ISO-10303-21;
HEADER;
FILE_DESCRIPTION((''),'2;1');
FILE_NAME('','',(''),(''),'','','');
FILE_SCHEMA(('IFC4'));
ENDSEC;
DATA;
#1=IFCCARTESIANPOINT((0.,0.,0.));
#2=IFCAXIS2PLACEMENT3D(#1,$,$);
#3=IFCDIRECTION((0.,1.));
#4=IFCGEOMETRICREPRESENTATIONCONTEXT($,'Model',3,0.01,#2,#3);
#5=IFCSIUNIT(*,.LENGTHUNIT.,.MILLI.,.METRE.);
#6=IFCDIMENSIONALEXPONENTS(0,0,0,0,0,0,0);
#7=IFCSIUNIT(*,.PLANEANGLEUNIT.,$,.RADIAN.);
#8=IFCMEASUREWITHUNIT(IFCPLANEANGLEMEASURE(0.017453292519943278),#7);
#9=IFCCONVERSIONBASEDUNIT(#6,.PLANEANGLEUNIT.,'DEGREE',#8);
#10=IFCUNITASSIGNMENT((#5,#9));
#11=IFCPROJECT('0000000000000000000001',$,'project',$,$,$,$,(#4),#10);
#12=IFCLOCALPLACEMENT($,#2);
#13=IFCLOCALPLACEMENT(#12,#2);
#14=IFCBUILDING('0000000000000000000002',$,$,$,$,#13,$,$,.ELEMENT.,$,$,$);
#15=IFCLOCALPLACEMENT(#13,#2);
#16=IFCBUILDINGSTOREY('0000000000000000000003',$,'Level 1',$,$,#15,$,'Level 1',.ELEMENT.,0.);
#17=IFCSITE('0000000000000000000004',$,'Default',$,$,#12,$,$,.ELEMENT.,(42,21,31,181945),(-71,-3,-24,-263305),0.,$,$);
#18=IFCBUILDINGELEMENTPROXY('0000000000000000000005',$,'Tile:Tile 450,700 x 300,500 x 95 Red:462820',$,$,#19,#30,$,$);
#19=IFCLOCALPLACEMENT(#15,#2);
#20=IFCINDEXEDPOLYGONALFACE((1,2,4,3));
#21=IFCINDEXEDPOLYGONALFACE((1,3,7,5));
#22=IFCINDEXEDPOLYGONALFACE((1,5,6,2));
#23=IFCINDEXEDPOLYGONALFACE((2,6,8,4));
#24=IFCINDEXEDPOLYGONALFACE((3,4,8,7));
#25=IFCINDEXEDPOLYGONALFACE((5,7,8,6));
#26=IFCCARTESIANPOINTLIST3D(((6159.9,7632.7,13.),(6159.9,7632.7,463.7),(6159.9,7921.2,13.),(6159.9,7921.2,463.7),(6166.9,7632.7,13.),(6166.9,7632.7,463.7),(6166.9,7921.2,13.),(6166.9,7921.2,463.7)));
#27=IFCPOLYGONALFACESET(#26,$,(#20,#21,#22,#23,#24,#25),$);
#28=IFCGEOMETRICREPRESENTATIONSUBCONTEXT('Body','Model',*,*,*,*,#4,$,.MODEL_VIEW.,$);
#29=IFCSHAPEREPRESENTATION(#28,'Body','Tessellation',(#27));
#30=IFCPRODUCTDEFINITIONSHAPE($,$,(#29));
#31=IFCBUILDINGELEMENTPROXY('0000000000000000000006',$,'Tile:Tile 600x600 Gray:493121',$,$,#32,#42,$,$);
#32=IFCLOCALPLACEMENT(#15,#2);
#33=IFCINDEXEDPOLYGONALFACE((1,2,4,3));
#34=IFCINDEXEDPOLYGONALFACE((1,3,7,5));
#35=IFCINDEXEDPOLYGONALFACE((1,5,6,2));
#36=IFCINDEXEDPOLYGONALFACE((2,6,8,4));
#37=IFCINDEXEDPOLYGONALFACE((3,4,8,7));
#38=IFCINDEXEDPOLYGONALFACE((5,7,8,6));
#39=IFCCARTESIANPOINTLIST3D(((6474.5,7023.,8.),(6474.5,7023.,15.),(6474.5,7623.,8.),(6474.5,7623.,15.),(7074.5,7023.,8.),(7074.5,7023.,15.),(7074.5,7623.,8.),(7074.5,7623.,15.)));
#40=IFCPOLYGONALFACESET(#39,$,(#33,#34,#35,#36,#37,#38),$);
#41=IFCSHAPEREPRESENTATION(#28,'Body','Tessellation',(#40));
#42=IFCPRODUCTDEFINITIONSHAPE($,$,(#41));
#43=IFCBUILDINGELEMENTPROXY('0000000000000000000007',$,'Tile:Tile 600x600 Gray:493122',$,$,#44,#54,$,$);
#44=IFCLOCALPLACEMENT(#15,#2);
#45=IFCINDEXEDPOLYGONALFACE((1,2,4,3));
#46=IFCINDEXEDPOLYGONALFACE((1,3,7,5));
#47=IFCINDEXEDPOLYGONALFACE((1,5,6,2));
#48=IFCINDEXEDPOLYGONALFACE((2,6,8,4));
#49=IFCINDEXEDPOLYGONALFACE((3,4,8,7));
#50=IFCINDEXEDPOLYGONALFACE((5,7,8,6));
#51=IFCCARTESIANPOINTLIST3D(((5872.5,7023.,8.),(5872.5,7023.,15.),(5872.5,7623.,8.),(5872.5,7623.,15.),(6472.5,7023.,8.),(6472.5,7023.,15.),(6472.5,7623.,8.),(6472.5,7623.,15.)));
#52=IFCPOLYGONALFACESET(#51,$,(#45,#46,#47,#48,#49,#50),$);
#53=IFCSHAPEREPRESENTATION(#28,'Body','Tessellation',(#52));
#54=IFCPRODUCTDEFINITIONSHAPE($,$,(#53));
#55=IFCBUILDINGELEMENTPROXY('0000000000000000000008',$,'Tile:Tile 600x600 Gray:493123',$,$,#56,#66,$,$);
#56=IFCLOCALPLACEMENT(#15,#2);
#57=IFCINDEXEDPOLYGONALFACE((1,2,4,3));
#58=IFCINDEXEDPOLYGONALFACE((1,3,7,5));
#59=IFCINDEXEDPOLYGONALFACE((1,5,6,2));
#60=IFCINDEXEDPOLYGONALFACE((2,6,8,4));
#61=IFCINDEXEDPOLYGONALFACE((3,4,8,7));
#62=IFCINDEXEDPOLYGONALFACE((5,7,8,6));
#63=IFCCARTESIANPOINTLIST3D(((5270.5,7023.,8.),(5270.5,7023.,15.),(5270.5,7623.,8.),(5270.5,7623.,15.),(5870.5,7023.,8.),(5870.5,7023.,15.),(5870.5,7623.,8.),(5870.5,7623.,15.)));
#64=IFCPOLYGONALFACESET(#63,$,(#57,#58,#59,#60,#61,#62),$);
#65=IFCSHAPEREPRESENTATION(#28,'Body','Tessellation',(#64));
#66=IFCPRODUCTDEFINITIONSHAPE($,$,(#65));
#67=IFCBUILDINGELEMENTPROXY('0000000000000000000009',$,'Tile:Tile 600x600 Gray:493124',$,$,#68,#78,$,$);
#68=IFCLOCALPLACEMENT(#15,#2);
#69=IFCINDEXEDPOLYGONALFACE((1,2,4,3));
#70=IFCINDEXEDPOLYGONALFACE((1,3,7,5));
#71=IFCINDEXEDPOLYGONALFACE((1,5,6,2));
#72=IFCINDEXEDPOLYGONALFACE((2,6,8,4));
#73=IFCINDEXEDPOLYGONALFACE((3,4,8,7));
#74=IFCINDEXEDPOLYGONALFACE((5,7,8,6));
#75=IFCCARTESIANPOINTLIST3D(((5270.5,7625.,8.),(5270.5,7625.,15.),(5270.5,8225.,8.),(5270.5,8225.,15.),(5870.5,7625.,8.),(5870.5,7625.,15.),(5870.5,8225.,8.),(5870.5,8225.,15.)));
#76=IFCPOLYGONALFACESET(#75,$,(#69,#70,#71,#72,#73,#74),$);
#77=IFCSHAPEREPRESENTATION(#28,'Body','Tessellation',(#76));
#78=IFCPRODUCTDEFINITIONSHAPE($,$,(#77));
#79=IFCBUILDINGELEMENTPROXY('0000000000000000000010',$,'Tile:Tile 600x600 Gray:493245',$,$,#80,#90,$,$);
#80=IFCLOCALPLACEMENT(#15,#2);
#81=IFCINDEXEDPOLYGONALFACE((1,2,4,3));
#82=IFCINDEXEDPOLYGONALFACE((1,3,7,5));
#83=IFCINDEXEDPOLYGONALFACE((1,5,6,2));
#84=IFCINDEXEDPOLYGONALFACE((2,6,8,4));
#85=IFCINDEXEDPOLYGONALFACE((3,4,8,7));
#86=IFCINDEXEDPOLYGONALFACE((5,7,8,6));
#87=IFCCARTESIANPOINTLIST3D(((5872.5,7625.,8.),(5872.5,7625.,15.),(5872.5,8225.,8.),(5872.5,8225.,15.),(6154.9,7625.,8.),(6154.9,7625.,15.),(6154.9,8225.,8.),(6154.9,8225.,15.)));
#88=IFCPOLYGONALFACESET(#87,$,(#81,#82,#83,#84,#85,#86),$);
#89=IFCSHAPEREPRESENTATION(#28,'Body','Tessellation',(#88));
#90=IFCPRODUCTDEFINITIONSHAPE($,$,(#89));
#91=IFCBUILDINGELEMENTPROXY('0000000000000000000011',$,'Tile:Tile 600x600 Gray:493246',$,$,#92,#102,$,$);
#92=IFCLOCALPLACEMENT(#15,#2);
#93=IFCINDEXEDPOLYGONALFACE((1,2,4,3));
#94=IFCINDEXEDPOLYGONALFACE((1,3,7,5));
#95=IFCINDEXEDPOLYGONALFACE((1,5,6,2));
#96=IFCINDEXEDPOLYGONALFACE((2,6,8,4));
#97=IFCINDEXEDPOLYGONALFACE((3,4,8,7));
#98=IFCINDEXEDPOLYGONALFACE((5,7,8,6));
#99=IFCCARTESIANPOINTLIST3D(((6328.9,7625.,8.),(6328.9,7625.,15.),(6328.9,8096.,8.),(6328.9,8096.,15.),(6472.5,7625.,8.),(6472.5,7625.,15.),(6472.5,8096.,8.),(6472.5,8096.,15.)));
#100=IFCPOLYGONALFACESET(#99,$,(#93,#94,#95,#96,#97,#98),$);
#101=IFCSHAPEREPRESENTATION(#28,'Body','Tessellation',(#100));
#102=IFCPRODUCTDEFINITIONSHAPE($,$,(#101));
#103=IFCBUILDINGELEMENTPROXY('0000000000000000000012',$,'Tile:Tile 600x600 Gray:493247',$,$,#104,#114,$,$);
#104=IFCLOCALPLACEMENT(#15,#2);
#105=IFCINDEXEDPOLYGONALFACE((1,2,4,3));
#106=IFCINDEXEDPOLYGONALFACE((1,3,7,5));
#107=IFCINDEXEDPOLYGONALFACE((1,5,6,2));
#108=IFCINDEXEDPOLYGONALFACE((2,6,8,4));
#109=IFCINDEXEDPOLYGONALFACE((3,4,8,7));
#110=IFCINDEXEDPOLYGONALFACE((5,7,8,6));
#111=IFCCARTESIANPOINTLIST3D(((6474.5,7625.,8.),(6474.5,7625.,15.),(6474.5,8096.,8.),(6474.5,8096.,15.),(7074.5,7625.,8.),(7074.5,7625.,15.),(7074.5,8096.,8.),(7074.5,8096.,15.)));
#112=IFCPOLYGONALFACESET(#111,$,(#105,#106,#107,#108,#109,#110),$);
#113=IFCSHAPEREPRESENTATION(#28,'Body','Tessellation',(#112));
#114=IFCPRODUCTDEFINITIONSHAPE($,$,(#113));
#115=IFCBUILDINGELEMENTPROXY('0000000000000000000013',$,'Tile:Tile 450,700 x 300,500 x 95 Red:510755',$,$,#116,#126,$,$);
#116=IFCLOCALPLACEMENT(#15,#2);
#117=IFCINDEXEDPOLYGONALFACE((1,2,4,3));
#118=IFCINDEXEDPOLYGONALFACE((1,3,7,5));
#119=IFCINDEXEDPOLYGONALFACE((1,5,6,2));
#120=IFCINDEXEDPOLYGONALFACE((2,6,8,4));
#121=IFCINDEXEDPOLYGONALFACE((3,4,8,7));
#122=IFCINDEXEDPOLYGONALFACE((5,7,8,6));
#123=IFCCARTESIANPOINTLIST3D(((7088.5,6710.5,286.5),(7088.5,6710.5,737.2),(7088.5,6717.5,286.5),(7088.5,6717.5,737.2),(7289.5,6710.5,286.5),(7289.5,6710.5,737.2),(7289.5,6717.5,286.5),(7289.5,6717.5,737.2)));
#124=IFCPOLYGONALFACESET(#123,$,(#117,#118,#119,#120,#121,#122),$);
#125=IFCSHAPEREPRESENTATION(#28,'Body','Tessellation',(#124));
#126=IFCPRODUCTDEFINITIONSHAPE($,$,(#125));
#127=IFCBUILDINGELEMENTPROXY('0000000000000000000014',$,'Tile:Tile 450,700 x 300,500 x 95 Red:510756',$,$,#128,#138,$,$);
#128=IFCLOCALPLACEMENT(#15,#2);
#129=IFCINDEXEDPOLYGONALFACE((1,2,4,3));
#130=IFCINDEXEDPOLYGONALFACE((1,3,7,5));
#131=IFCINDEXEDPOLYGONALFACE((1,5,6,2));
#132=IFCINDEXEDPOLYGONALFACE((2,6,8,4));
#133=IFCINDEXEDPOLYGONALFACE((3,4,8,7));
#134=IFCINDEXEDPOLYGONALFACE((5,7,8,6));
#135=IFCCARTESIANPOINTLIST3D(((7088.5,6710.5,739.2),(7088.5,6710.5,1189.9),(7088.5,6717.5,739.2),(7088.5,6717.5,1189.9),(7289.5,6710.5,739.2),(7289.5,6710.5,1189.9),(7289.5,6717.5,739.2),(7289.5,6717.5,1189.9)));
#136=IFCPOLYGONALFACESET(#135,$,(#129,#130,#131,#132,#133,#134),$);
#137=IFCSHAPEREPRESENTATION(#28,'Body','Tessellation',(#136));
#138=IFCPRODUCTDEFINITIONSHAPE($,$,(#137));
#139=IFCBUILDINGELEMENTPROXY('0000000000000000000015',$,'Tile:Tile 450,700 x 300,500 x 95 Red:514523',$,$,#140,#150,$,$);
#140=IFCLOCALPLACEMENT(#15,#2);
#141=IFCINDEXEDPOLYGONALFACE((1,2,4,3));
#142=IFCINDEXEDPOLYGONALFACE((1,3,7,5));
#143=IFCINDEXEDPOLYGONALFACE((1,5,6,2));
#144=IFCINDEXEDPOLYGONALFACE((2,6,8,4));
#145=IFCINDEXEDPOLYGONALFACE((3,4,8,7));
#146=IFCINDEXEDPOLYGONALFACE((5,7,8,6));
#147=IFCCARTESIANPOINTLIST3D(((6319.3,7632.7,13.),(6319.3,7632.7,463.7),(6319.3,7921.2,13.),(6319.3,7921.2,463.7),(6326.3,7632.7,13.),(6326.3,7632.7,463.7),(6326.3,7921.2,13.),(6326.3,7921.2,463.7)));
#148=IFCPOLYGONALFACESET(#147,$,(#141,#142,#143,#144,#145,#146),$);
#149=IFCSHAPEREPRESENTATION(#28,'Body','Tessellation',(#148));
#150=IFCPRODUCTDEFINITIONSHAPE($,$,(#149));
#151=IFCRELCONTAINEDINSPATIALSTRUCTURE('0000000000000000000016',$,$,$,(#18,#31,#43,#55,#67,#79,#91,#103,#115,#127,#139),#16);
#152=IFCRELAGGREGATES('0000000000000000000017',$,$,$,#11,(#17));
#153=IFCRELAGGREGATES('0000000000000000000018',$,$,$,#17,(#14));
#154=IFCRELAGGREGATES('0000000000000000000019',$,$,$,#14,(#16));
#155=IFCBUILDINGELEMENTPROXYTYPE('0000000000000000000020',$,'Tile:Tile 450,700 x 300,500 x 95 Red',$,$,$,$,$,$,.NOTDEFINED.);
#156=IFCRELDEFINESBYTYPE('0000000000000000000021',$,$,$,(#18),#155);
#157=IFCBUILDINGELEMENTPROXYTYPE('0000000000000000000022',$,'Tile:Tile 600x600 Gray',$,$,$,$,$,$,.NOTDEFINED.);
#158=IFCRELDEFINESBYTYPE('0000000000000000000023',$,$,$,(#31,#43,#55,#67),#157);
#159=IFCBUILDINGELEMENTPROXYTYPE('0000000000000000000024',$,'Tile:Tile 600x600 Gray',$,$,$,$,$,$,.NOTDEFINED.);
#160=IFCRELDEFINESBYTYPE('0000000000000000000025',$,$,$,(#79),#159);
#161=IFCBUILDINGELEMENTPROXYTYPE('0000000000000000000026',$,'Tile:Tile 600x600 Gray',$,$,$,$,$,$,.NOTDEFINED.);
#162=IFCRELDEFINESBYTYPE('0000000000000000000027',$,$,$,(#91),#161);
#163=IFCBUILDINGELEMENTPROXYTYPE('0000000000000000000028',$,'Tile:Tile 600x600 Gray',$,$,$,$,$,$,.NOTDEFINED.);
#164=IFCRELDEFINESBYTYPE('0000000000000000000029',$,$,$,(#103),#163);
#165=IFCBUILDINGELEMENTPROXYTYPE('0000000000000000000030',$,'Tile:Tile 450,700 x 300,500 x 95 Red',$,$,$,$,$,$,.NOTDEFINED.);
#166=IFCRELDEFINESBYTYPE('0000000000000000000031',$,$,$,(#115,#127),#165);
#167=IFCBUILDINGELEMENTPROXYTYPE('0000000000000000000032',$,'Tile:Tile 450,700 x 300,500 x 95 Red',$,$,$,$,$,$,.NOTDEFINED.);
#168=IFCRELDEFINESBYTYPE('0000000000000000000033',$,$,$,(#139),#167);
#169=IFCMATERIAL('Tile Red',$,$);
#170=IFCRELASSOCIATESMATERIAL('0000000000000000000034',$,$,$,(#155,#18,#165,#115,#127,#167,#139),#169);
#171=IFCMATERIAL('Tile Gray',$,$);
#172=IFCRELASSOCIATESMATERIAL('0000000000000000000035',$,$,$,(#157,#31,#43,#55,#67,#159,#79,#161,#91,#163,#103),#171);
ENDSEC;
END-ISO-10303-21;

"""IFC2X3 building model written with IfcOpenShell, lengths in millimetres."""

from ifc_helpers import new_model, entity, si_unit, converted_unit, direction, frame, frame_2d, origin, origin_2d_with_axis, place, context, subcontext, project, spatial, rectangle, extrude, source, transform, mapped, material, type_object, type_shapes, element, save


model = new_model("IFC2X3")

# Units and contexts
model_context = context("Model", 3, precision=0.01, world=origin(), true_north=direction((0.0, 1.0)))
body_context = subcontext(model_context, "Body", "Model", "MODEL_VIEW")
ifc_project = project(units=[si_unit("LENGTHUNIT", "METRE", prefix="MILLI"), converted_unit("PLANEANGLEUNIT", "DEGREE", entity("IfcPlaneAngleMeasure", 0.017453292519943278), si_unit("PLANEANGLEUNIT", "RADIAN"), dimensions=[0, 0, 0, 0, 0, 0, 0])], contexts=[model_context])

# Site, building, storey
site_placement = place(None, origin())
site = spatial("IfcSite", under=ifc_project, at=site_placement, Name="Default", CompositionType="ELEMENT", RefLatitude=(42, 21, 31, 181945), RefLongitude=(-71, -3, -24, -263305), RefElevation=0.0)
building_placement = place(site_placement, origin())
building = spatial("IfcBuilding", under=site, at=building_placement, CompositionType="ELEMENT")
storey_placement = place(building_placement, origin())
storey = spatial("IfcBuildingStorey", under=building, at=storey_placement, Name="Level 1", LongName="Level 1", CompositionType="ELEMENT", Elevation=0.0)

# Building element proxies
ifc_material_1 = material(Name="Tile Gray")
ifc_material_2 = material(Name="Tile Red")
building_element_proxy_type_1 = type_object("IfcBuildingElementProxyType", Name="Tile:Tile 450,700 x 300,500 x 95 Red", PredefinedType="NOTDEFINED", material=ifc_material_2)
shared_shape_1 = source(origin(), body_context, "Body", "SweptSolid", [
    extrude(rectangle(XDim=450.7, YDim=288.5, at=origin_2d_with_axis()), frame((-144.2, 225.4, 0.0), z_axis=(0.0, 0.0, 1.0), x_axis=(0.0, 1.0, 0.0)), (0.0, 0.0, 1.0), 7.0),
])
type_shapes(building_element_proxy_type_1, [shared_shape_1])
proxy_1_placement = place(storey_placement, frame((6166.9, 7632.7, 13.0), z_axis=(-1.0, 0.0, 0.0), x_axis=(0.0, -1.0, 0.0)))
element("IfcBuildingElementProxy", 1, at=proxy_1_placement, inside=storey, type_object=building_element_proxy_type_1, material=ifc_material_2, Name="Tile:Tile 450,700 x 300,500 x 95 Red:462820", context=body_context, shape_type="MappedRepresentation", body=[
    mapped(shared_shape_1, transform((0.0, 0.0, 0.0), scale=1.0)),
])
building_element_proxy_type_2 = type_object("IfcBuildingElementProxyType", Name="Tile:Tile 600x600 Gray", PredefinedType="NOTDEFINED", material=ifc_material_1)
shared_shape_2 = source(origin(), body_context, "Body", "SweptSolid", [
    extrude(rectangle(XDim=600.0, YDim=600.0, at=frame_2d((0.0, 0.0), x_axis=(1.0, 0.0))), frame((-300.0, -300.0, 0.0), z_axis=(0.0, 0.0, 1.0), x_axis=(0.0, -1.0, 0.0)), (0.0, 0.0, 1.0), 7.0),
])
type_shapes(building_element_proxy_type_2, [shared_shape_2])
for number, where, z_axis, x_axis, name in (
    (2, (7074.5, 7023.0, 8.0), (0.0, 0.0, 1.0), (0.0, -1.0, 0.0), "Tile:Tile 600x600 Gray:493121"),
    (3, (6472.5, 7023.0, 8.0), (0.0, 0.0, 1.0), (0.0, -1.0, 0.0), "Tile:Tile 600x600 Gray:493122"),
    (4, (5870.5, 7023.0, 8.0), (0.0, 0.0, 1.0), (0.0, -1.0, 0.0), "Tile:Tile 600x600 Gray:493123"),
    (5, (5870.5, 7625.0, 8.0), (0.0, 0.0, 1.0), (0.0, -1.0, 0.0), "Tile:Tile 600x600 Gray:493124"),
):
    element("IfcBuildingElementProxy", number, at=place(storey_placement, frame(where, z_axis=z_axis, x_axis=x_axis)), inside=storey, type_object=building_element_proxy_type_2, material=ifc_material_1, Name=name, context=body_context, shape_type="MappedRepresentation", body=[
        mapped(shared_shape_2, transform((0.0, 0.0, 0.0), scale=1.0)),
    ])
building_element_proxy_type_3 = type_object("IfcBuildingElementProxyType", Name="Tile:Tile 600x600 Gray", PredefinedType="NOTDEFINED", material=ifc_material_1)
shared_shape_3 = source(origin(), body_context, "Body", "SweptSolid", [
    extrude(rectangle(XDim=282.4, YDim=600.0, at=frame_2d((0.0, 0.0), x_axis=(1.0, 0.0))), frame((-300.0, -141.2, 0.0), z_axis=(0.0, 0.0, 1.0), x_axis=(0.0, -1.0, 0.0)), (0.0, 0.0, 1.0), 7.0),
])
type_shapes(building_element_proxy_type_3, [shared_shape_3])
proxy_2_placement = place(storey_placement, frame((6154.9, 7625.0, 8.0), z_axis=(0.0, 0.0, 1.0), x_axis=(0.0, -1.0, 0.0)))
element("IfcBuildingElementProxy", 6, at=proxy_2_placement, inside=storey, type_object=building_element_proxy_type_3, material=ifc_material_1, Name="Tile:Tile 600x600 Gray:493245", context=body_context, shape_type="MappedRepresentation", body=[
    mapped(shared_shape_3, transform((0.0, 0.0, 0.0), scale=1.0)),
])
building_element_proxy_type_4 = type_object("IfcBuildingElementProxyType", Name="Tile:Tile 600x600 Gray", PredefinedType="NOTDEFINED", material=ifc_material_1)
shared_shape_4 = source(origin(), body_context, "Body", "SweptSolid", [
    extrude(rectangle(XDim=471.0, YDim=143.6, at=frame_2d((0.0, 0.0), x_axis=(1.0, 0.0))), frame((-235.5, -71.8, 0.0), z_axis=(0.0, 0.0, 1.0), x_axis=(-1.0, 0.0, 0.0)), (0.0, 0.0, 1.0), 7.0),
])
type_shapes(building_element_proxy_type_4, [shared_shape_4])
proxy_3_placement = place(storey_placement, frame((6472.5, 7625.0, 8.0), z_axis=(0.0, 0.0, 1.0), x_axis=(0.0, -1.0, 0.0)))
element("IfcBuildingElementProxy", 7, at=proxy_3_placement, inside=storey, type_object=building_element_proxy_type_4, material=ifc_material_1, Name="Tile:Tile 600x600 Gray:493246", context=body_context, shape_type="MappedRepresentation", body=[
    mapped(shared_shape_4, transform((0.0, 0.0, 0.0), scale=1.0)),
])
building_element_proxy_type_5 = type_object("IfcBuildingElementProxyType", Name="Tile:Tile 600x600 Gray", PredefinedType="NOTDEFINED", material=ifc_material_1)
shared_shape_5 = source(origin(), body_context, "Body", "SweptSolid", [
    extrude(rectangle(XDim=471.0, YDim=600.0, at=origin_2d_with_axis()), frame((-235.5, -300.0, 0.0), z_axis=(0.0, 0.0, 1.0), x_axis=(-1.0, 0.0, 0.0)), (0.0, 0.0, 1.0), 7.0),
])
type_shapes(building_element_proxy_type_5, [shared_shape_5])
proxy_4_placement = place(storey_placement, frame((7074.5, 7625.0, 8.0), z_axis=(0.0, 0.0, 1.0), x_axis=(0.0, -1.0, 0.0)))
element("IfcBuildingElementProxy", 8, at=proxy_4_placement, inside=storey, type_object=building_element_proxy_type_5, material=ifc_material_1, Name="Tile:Tile 600x600 Gray:493247", context=body_context, shape_type="MappedRepresentation", body=[
    mapped(shared_shape_5, transform((0.0, 0.0, 0.0), scale=1.0)),
])
building_element_proxy_type_6 = type_object("IfcBuildingElementProxyType", Name="Tile:Tile 450,700 x 300,500 x 95 Red", PredefinedType="NOTDEFINED", material=ifc_material_2)
shared_shape_6 = source(origin(), body_context, "Body", "SweptSolid", [
    extrude(rectangle(XDim=201.0, YDim=450.7, at=frame_2d((0.0, 0.0), x_axis=(1.0, 0.0))), frame((-100.5, -225.4, 0.0), z_axis=(0.0, 0.0, 1.0), x_axis=(-1.0, 0.0, 0.0)), (0.0, 0.0, 1.0), 7.0),
])
type_shapes(building_element_proxy_type_6, [shared_shape_6])
for number, where, z_axis, x_axis, name in (
    (9, (7088.5, 6717.5, 286.5), (0.0, -1.0, 0.0), (-1.0, 0.0, 0.0), "Tile:Tile 450,700 x 300,500 x 95 Red:510755"),
    (10, (7088.5, 6717.5, 739.2), (0.0, -1.0, 0.0), (-1.0, 0.0, 0.0), "Tile:Tile 450,700 x 300,500 x 95 Red:510756"),
):
    element("IfcBuildingElementProxy", number, at=place(storey_placement, frame(where, z_axis=z_axis, x_axis=x_axis)), inside=storey, type_object=building_element_proxy_type_6, material=ifc_material_2, Name=name, context=body_context, shape_type="MappedRepresentation", body=[
        mapped(shared_shape_6, transform((0.0, 0.0, 0.0), scale=1.0)),
    ])
building_element_proxy_type_7 = type_object("IfcBuildingElementProxyType", Name="Tile:Tile 450,700 x 300,500 x 95 Red", PredefinedType="NOTDEFINED", material=ifc_material_2)
shared_shape_7 = source(origin(), body_context, "Body", "SweptSolid", [
    extrude(rectangle(XDim=288.5, YDim=450.7, at=frame_2d((0.0, 0.0), x_axis=(1.0, 0.0))), frame((-144.2, -225.4, 0.0), z_axis=(0.0, 0.0, 1.0), x_axis=(-1.0, 0.0, 0.0)), (0.0, 0.0, 1.0), 7.0),
])
type_shapes(building_element_proxy_type_7, [shared_shape_7])
proxy_5_placement = place(storey_placement, frame((6319.3, 7632.7, 13.0), z_axis=(1.0, 0.0, 0.0), x_axis=(0.0, -1.0, 0.0)))
element("IfcBuildingElementProxy", 11, at=proxy_5_placement, inside=storey, type_object=building_element_proxy_type_7, material=ifc_material_2, Name="Tile:Tile 450,700 x 300,500 x 95 Red:514523", context=body_context, shape_type="MappedRepresentation", body=[
    mapped(shared_shape_7, transform((0.0, 0.0, 0.0), scale=1.0)),
])

save(model, "model.ifc")
